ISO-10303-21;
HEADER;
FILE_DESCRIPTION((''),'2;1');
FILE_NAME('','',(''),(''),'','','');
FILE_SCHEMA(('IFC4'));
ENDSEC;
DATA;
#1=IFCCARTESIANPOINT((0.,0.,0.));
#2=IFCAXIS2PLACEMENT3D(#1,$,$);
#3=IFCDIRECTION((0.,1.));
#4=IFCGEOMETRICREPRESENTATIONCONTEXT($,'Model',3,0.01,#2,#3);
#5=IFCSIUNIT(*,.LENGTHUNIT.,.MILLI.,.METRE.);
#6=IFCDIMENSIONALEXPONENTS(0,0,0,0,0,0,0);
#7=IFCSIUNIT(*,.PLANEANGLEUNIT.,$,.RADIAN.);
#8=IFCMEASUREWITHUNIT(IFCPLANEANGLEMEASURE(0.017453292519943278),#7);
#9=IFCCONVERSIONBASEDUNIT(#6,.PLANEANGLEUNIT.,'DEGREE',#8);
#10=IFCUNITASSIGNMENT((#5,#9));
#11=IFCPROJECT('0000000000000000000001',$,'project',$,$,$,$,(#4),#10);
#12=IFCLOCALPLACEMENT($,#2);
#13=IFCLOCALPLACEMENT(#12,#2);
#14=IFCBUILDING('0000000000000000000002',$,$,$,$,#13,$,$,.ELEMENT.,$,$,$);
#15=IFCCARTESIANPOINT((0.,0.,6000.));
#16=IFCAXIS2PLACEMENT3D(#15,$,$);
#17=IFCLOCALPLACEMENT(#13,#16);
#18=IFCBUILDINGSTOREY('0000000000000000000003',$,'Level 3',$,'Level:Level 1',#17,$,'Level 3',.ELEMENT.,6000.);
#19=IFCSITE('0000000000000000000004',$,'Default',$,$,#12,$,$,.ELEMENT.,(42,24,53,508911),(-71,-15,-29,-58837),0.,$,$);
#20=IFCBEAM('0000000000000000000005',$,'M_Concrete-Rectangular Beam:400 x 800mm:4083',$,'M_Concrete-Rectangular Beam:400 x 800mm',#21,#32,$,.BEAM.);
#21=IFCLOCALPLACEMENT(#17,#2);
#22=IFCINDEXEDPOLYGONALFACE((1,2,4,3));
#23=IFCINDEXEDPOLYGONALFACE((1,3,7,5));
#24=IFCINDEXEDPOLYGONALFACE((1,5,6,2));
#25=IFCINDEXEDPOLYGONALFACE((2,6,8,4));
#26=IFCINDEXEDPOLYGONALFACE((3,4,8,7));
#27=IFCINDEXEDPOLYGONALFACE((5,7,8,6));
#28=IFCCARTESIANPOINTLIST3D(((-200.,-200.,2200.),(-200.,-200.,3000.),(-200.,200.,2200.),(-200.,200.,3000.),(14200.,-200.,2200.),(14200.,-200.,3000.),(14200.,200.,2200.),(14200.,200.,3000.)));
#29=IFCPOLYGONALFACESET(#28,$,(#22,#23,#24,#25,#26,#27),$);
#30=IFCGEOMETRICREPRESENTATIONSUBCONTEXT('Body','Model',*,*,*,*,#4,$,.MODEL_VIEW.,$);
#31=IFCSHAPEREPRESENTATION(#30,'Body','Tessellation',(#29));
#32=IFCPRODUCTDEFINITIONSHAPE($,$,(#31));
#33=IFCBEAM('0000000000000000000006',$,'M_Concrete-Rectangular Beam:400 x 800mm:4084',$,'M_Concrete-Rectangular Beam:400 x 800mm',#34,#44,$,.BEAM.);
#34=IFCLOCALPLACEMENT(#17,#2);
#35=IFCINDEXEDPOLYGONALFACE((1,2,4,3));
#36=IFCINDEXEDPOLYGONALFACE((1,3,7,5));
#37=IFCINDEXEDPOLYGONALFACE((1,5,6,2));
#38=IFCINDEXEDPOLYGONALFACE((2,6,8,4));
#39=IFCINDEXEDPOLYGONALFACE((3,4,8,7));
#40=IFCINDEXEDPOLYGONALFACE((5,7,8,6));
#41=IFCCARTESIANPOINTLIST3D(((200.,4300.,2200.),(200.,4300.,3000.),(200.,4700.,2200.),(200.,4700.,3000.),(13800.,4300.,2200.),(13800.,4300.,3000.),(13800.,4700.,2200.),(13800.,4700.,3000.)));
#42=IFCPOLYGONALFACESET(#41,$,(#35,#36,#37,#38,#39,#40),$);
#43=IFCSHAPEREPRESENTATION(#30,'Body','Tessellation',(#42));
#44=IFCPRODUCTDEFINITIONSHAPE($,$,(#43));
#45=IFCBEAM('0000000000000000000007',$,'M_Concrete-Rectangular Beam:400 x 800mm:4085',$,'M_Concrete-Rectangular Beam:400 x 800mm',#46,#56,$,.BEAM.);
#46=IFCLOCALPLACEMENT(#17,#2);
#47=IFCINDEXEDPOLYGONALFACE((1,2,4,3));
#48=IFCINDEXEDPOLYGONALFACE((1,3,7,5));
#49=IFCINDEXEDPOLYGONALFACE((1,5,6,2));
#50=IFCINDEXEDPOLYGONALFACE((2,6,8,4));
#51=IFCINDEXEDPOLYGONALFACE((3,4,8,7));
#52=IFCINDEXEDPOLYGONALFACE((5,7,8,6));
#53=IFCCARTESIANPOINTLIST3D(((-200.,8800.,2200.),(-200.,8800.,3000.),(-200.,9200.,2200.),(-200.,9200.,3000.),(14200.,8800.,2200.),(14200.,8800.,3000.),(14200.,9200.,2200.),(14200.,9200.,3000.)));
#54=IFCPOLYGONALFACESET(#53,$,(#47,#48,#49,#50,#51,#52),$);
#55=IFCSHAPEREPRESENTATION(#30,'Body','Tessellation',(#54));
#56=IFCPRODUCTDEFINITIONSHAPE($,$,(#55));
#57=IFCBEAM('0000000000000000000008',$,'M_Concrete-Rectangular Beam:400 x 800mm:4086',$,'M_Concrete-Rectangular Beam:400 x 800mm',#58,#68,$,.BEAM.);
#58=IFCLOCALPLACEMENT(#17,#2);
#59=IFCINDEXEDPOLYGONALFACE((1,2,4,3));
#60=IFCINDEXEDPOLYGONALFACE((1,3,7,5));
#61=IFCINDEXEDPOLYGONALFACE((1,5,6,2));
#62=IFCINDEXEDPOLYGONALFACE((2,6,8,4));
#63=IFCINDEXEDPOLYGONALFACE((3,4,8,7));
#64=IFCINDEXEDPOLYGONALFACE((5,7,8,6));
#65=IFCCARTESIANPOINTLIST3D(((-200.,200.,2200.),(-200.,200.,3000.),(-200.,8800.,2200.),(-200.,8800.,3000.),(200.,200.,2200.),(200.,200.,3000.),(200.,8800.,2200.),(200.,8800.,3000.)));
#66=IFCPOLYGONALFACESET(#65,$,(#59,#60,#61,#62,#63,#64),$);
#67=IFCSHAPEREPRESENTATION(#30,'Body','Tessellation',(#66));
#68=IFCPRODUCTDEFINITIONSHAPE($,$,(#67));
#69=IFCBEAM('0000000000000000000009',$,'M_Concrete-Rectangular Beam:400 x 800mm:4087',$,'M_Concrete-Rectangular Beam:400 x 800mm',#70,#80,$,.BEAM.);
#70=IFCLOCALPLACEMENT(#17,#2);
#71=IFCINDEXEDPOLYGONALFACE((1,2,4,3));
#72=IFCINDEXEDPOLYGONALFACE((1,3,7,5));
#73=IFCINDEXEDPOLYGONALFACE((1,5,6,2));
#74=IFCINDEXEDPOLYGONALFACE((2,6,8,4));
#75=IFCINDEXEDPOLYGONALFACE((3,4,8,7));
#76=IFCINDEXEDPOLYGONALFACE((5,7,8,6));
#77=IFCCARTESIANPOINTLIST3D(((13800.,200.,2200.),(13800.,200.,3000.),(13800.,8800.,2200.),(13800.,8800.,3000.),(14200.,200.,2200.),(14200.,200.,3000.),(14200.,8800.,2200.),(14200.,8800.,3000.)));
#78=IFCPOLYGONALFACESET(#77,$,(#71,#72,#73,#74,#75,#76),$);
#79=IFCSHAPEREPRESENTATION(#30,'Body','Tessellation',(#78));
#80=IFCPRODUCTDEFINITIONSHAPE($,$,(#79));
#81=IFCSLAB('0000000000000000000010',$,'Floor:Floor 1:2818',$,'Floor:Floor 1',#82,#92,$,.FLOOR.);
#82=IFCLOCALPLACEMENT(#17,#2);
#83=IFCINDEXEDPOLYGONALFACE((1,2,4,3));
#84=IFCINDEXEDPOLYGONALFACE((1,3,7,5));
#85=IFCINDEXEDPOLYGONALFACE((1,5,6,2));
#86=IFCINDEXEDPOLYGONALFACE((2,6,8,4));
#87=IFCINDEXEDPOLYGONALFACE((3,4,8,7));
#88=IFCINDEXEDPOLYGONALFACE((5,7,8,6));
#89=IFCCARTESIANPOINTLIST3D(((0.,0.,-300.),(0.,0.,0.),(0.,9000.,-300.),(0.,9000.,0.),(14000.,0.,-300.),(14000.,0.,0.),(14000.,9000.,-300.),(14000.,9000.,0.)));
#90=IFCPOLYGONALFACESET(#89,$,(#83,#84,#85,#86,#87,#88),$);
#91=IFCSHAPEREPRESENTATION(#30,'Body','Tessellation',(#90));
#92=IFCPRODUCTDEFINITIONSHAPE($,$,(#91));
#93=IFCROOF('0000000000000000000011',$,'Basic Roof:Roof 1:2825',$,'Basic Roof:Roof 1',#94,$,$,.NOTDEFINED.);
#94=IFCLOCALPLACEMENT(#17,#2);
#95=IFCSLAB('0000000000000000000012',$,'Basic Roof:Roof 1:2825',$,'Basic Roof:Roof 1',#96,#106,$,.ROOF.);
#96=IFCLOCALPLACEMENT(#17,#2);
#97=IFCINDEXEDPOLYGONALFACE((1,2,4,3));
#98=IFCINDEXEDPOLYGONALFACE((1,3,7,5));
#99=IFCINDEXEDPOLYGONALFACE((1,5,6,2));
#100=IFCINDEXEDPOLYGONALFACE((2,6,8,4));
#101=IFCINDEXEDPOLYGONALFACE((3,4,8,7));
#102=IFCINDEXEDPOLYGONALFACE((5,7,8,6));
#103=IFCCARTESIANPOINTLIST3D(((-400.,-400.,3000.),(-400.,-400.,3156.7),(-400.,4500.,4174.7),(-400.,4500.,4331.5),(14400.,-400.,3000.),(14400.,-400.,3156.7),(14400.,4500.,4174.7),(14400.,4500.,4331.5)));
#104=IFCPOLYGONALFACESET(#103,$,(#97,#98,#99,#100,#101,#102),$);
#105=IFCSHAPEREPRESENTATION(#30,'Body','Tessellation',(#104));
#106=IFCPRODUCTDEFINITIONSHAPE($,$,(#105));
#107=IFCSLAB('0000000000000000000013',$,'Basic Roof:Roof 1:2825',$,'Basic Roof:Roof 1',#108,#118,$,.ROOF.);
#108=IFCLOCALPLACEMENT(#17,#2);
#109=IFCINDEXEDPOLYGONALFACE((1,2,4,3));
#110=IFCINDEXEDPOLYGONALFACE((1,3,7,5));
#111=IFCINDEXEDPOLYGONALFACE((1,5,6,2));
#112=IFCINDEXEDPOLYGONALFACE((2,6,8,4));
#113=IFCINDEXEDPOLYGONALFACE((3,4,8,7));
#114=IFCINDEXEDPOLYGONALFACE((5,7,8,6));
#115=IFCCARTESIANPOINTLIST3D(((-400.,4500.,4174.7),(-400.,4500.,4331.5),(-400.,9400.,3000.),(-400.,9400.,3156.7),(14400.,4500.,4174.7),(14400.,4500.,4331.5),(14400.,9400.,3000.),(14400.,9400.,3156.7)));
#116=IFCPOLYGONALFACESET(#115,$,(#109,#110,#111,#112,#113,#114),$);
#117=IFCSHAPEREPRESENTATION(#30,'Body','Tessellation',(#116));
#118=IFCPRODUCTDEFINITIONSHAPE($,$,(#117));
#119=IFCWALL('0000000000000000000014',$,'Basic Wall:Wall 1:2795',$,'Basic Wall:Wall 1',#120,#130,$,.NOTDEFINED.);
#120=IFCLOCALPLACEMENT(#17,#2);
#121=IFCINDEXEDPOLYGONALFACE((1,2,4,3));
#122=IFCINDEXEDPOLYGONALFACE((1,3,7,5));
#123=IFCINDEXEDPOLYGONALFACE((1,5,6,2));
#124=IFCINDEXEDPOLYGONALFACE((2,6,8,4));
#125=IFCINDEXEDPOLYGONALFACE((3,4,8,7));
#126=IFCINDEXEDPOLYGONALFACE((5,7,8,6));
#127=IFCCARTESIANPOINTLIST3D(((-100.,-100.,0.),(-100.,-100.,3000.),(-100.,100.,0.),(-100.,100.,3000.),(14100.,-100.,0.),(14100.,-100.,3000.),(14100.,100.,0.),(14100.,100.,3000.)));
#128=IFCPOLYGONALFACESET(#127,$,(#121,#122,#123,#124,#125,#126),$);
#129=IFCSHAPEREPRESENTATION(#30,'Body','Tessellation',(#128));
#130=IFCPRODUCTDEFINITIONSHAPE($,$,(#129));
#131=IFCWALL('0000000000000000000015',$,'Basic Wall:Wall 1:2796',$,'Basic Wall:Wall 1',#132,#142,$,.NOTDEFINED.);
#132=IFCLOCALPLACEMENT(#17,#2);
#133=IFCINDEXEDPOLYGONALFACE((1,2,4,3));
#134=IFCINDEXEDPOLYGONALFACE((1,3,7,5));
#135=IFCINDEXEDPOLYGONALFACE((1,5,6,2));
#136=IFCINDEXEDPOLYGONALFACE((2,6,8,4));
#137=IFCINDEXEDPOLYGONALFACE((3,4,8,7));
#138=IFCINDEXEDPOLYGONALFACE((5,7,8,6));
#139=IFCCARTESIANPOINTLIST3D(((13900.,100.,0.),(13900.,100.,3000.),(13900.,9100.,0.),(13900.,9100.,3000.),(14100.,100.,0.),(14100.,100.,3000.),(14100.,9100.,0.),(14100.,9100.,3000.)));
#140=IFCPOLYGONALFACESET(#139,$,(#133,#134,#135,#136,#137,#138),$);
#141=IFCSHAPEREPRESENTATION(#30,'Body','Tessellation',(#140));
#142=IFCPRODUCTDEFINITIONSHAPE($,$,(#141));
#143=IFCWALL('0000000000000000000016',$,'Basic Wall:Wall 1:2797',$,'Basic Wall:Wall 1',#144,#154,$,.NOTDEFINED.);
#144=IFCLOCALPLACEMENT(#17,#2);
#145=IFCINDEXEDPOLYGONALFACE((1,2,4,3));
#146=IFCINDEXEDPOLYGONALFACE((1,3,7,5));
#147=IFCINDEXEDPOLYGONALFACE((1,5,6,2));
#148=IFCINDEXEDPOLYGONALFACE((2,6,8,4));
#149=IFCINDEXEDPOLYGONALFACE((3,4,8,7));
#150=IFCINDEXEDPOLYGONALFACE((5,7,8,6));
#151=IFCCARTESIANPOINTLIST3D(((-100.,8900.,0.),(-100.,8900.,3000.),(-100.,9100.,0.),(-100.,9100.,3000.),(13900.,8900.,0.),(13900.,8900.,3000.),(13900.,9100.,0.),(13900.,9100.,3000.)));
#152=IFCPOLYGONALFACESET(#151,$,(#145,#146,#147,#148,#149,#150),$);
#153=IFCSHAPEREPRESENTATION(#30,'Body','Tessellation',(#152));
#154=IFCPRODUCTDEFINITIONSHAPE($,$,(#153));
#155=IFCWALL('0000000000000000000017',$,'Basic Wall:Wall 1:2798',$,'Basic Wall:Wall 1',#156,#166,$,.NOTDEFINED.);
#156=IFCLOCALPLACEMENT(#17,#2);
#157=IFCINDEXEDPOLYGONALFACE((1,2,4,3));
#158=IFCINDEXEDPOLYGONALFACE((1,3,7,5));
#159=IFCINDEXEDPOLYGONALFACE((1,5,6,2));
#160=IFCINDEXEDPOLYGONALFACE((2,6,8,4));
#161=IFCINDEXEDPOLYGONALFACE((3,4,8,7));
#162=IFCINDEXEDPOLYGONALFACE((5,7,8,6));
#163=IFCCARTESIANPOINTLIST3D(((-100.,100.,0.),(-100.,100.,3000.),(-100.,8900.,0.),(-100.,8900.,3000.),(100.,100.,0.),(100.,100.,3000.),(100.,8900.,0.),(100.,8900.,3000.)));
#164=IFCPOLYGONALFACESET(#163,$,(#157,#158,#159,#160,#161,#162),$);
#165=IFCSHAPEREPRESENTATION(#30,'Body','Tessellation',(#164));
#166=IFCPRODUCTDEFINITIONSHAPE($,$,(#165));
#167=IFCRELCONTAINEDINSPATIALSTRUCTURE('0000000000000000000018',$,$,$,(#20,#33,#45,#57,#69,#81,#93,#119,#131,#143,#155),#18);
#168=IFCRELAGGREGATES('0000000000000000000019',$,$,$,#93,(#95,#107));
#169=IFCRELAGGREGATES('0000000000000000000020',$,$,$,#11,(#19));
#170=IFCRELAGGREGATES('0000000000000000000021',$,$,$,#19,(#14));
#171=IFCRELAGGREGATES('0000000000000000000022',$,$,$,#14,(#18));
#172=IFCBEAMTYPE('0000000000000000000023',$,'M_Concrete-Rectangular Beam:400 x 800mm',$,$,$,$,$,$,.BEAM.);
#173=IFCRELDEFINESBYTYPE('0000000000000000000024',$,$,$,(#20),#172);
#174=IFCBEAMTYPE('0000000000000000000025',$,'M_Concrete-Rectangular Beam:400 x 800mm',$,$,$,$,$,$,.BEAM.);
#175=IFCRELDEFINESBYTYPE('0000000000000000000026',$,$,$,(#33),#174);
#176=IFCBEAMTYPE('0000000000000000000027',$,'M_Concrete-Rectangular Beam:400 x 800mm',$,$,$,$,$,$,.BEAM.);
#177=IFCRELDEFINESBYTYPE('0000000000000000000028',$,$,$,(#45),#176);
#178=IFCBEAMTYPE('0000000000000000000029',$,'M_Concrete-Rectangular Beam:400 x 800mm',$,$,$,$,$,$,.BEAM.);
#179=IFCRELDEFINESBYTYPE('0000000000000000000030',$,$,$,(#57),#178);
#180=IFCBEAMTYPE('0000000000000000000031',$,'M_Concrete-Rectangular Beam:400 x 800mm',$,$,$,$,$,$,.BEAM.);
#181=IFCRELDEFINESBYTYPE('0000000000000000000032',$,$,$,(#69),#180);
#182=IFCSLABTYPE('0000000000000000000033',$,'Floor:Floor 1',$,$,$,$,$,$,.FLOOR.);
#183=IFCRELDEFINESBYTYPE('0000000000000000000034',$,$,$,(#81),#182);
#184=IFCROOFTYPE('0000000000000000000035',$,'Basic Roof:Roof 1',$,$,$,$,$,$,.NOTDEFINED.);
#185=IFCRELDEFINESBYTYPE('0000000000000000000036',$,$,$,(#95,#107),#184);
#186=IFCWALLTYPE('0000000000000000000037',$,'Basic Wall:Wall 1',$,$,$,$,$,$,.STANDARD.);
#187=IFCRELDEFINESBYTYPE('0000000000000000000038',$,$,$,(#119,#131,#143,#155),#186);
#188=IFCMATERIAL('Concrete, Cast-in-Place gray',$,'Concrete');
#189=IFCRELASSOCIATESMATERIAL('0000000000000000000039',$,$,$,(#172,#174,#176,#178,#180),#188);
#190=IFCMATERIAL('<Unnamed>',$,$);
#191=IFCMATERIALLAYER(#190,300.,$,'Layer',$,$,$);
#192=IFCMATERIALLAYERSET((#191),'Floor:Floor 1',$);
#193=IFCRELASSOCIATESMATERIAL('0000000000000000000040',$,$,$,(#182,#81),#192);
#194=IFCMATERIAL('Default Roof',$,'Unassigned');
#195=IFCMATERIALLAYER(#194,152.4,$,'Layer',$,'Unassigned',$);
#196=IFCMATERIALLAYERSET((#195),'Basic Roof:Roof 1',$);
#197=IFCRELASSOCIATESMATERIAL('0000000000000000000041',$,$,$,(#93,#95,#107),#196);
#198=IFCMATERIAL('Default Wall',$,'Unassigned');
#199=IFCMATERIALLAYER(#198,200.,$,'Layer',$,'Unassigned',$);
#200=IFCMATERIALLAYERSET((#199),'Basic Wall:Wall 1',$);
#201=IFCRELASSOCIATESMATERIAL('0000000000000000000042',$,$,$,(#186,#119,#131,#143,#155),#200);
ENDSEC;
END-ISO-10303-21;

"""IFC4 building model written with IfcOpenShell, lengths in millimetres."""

from ifc_helpers import new_model, entity, si_unit, converted_unit, direction, frame, frame_2d, origin, origin_2d_with_axis, place, context, subcontext, project, spatial, rectangle, extrude, source, transform, mapped, material, layer, layer_set, layer_usage, material_profile, profile_set, type_object, type_shapes, element, aggregate, save


model = new_model("IFC4")

# Units and contexts
model_context = context("Model", 3, precision=0.01, world=origin(), true_north=direction((0.0, 1.0)))
body_context = subcontext(model_context, "Body", "Model", "MODEL_VIEW")
ifc_project = project(units=[si_unit("LENGTHUNIT", "METRE", prefix="MILLI"), converted_unit("PLANEANGLEUNIT", "DEGREE", entity("IfcPlaneAngleMeasure", 0.017453292519943278), si_unit("PLANEANGLEUNIT", "RADIAN"), dimensions=[0, 0, 0, 0, 0, 0, 0])], contexts=[model_context])

# Site, building, storey
site_placement = place(None, origin())
site = spatial("IfcSite", under=ifc_project, at=site_placement, Name="Default", CompositionType="ELEMENT", RefLatitude=(42, 24, 53, 508911), RefLongitude=(-71, -15, -29, -58837), RefElevation=0.0)
building_placement = place(site_placement, origin())
building = spatial("IfcBuilding", under=site, at=building_placement, CompositionType="ELEMENT")
storey_placement = place(building_placement, frame((0.0, 0.0, 6000.0)))
storey = spatial("IfcBuildingStorey", under=building, at=storey_placement, Name="Level 3", ObjectType="Level:Level 1", LongName="Level 3", CompositionType="ELEMENT", Elevation=6000.0)

# Beams
ifc_material_1 = material(Name="Concrete, Cast-in-Place gray", Category="Concrete")
ifc_material_profile = material_profile(ifc_material_1, rectangle(XDim=800.0, YDim=400.0, at=origin_2d_with_axis()), Name="400 x 800mm")
ifc_profile_set = profile_set([ifc_material_profile], Name="400 x 800mm")
beam_type_1 = type_object("IfcBeamType", Name="M_Concrete-Rectangular Beam:400 x 800mm", PredefinedType="BEAM", material=ifc_profile_set)
shared_shape_1 = source(origin(), body_context, "Body", "SweptSolid", [
    extrude(rectangle(XDim=800.0, YDim=400.0, at=origin_2d_with_axis()), frame((-200.0, 0.0, 8600.0), z_axis=(1.0, 0.0, 0.0), x_axis=(0.0, 0.0, -1.0)), (0.0, 0.0, 1.0), 14400.0),
])
type_shapes(beam_type_1, [shared_shape_1])
beam_1_placement = place(storey_placement, frame((0.0, 0.0, -6000.0)))
element("IfcBeam", 1, at=beam_1_placement, inside=storey, type_object=beam_type_1, Name="M_Concrete-Rectangular Beam:400 x 800mm:4083", ObjectType="M_Concrete-Rectangular Beam:400 x 800mm", PredefinedType="BEAM", context=body_context, shape_type="MappedRepresentation", body=[
    mapped(shared_shape_1, transform((0.0, 0.0, 0.0), scale=1.0)),
])
beam_type_2 = type_object("IfcBeamType", Name="M_Concrete-Rectangular Beam:400 x 800mm", PredefinedType="BEAM", material=ifc_profile_set)
shared_shape_2 = source(origin(), body_context, "Body", "SweptSolid", [
    extrude(rectangle(XDim=800.0, YDim=400.0, at=origin_2d_with_axis()), frame((200.0, 4500.0, 8600.0), z_axis=(1.0, 0.0, 0.0), x_axis=(0.0, 0.0, -1.0)), (0.0, 0.0, 1.0), 13600.0),
])
type_shapes(beam_type_2, [shared_shape_2])
beam_2_placement = place(storey_placement, frame((0.0, 0.0, -6000.0)))
element("IfcBeam", 2, at=beam_2_placement, inside=storey, type_object=beam_type_2, Name="M_Concrete-Rectangular Beam:400 x 800mm:4084", ObjectType="M_Concrete-Rectangular Beam:400 x 800mm", PredefinedType="BEAM", context=body_context, shape_type="MappedRepresentation", body=[
    mapped(shared_shape_2, transform((0.0, 0.0, 0.0), scale=1.0)),
])
beam_type_3 = type_object("IfcBeamType", Name="M_Concrete-Rectangular Beam:400 x 800mm", PredefinedType="BEAM", material=ifc_profile_set)
shared_shape_3 = source(origin(), body_context, "Body", "SweptSolid", [
    extrude(rectangle(XDim=800.0, YDim=400.0, at=frame_2d((0.0, 0.0), x_axis=(1.0, 0.0))), frame((-200.0, 9000.0, 8600.0), z_axis=(1.0, 0.0, 0.0), x_axis=(0.0, 0.0, -1.0)), (0.0, 0.0, 1.0), 14400.0),
])
type_shapes(beam_type_3, [shared_shape_3])
beam_3_placement = place(storey_placement, frame((0.0, 0.0, -6000.0)))
element("IfcBeam", 3, at=beam_3_placement, inside=storey, type_object=beam_type_3, Name="M_Concrete-Rectangular Beam:400 x 800mm:4085", ObjectType="M_Concrete-Rectangular Beam:400 x 800mm", PredefinedType="BEAM", context=body_context, shape_type="MappedRepresentation", body=[
    mapped(shared_shape_3, transform((0.0, 0.0, 0.0), scale=1.0)),
])
beam_type_4 = type_object("IfcBeamType", Name="M_Concrete-Rectangular Beam:400 x 800mm", PredefinedType="BEAM", material=ifc_profile_set)
shared_shape_4 = source(origin(), body_context, "Body", "SweptSolid", [
    extrude(rectangle(XDim=800.0, YDim=400.0, at=frame_2d((0.0, 0.0), x_axis=(0.0, 1.0))), frame((0.0, 200.0, 8600.0), z_axis=(0.0, 1.0, 0.0), x_axis=(-1.0, 0.0, 0.0)), (0.0, 0.0, 1.0), 8600.0),
])
type_shapes(beam_type_4, [shared_shape_4])
beam_4_placement = place(storey_placement, frame((0.0, 0.0, -6000.0)))
element("IfcBeam", 4, at=beam_4_placement, inside=storey, type_object=beam_type_4, Name="M_Concrete-Rectangular Beam:400 x 800mm:4086", ObjectType="M_Concrete-Rectangular Beam:400 x 800mm", PredefinedType="BEAM", context=body_context, shape_type="MappedRepresentation", body=[
    mapped(shared_shape_4, transform((0.0, 0.0, 0.0), scale=1.0)),
])
beam_type_5 = type_object("IfcBeamType", Name="M_Concrete-Rectangular Beam:400 x 800mm", PredefinedType="BEAM", material=ifc_profile_set)
shared_shape_5 = source(origin(), body_context, "Body", "SweptSolid", [
    extrude(rectangle(XDim=800.0, YDim=400.0, at=frame_2d((0.0, 0.0), x_axis=(0.0, 1.0))), frame((14000.0, 200.0, 8600.0), z_axis=(0.0, 1.0, 0.0), x_axis=(-1.0, 0.0, 0.0)), (0.0, 0.0, 1.0), 8600.0),
])
type_shapes(beam_type_5, [shared_shape_5])
beam_5_placement = place(storey_placement, frame((0.0, 0.0, -6000.0)))
element("IfcBeam", 5, at=beam_5_placement, inside=storey, type_object=beam_type_5, Name="M_Concrete-Rectangular Beam:400 x 800mm:4087", ObjectType="M_Concrete-Rectangular Beam:400 x 800mm", PredefinedType="BEAM", context=body_context, shape_type="MappedRepresentation", body=[
    mapped(shared_shape_5, transform((0.0, 0.0, 0.0), scale=1.0)),
])

# Slab
ifc_material_2 = material(Name="<Unnamed>")
ifc_layer_1 = layer(ifc_material_2, 300.0, Name="Layer")
ifc_layer_set_1 = layer_set([ifc_layer_1], Name="Floor:Floor 1")
ifc_layer_usage_1 = layer_usage(ifc_layer_set_1, "AXIS3", "POSITIVE", 0.0)
slab_type = type_object("IfcSlabType", Name="Floor:Floor 1", PredefinedType="FLOOR", material=ifc_layer_set_1)
slab_1_placement = place(storey_placement, origin())
element("IfcSlab", 6, at=slab_1_placement, inside=storey, type_object=slab_type, material=ifc_layer_usage_1, Name="Floor:Floor 1:2818", ObjectType="Floor:Floor 1", PredefinedType="FLOOR", context=body_context, shape_type="SweptSolid", body=[
    extrude(rectangle(XDim=9000.0, YDim=14000.0, at=origin_2d_with_axis()), frame((7000.0, 4500.0, 0.0), z_axis=(0.0, 0.0, -1.0), x_axis=(0.0, 1.0, 0.0)), (0.0, 0.0, 1.0), 300.0),
])

# Roof, slabs
ifc_material_3 = material(Name="Default Roof", Category="Unassigned")
ifc_layer_2 = layer(ifc_material_3, 152.4, Name="Layer", Category="Unassigned")
ifc_layer_set_2 = layer_set([ifc_layer_2], Name="Basic Roof:Roof 1")
roof_placement = place(storey_placement, frame((-400.0, -400.0, 3000.0)))
roof = element("IfcRoof", 7, at=roof_placement, inside=storey, material=ifc_layer_set_2, Name="Basic Roof:Roof 1:2825", ObjectType="Basic Roof:Roof 1", PredefinedType="NOTDEFINED")
roof_type = type_object("IfcRoofType", Name="Basic Roof:Roof 1", PredefinedType="NOTDEFINED")
slab_2_placement = place(roof_placement, origin())
slab_2 = element("IfcSlab", 8, at=slab_2_placement, type_object=roof_type, material=ifc_layer_set_2, Name="Basic Roof:Roof 1:2825", ObjectType="Basic Roof:Roof 1", PredefinedType="ROOF", context=body_context, shape_type="SweptSolid", body=[
    extrude(rectangle(XDim=14800.0, YDim=5038.9, at=frame_2d((0.0, 0.0), x_axis=(-1.0, 0.0))), frame((7400.0, 2450.0, 587.4), z_axis=(0.0, -0.233137, 0.972444), x_axis=(1.0, 0.0, 0.0)), (0.0, 0.233137, 0.972444), 156.7),
])
slab_3_placement = place(roof_placement, origin())
slab_3 = element("IfcSlab", 9, at=slab_3_placement, type_object=roof_type, material=ifc_layer_set_2, Name="Basic Roof:Roof 1:2825", ObjectType="Basic Roof:Roof 1", PredefinedType="ROOF", context=body_context, shape_type="SweptSolid", body=[
    extrude(rectangle(XDim=5038.9, YDim=14800.0, at=frame_2d((0.0, 0.0), x_axis=(0.0, -1.0))), frame((7400.0, 7350.0, 587.4), z_axis=(0.0, 0.233137, 0.972444), x_axis=(1.0, 0.0, 0.0)), (0.0, -0.233137, 0.972444), 156.7),
])
aggregate(roof, [slab_2, slab_3])

# Walls
ifc_material_4 = material(Name="Default Wall", Category="Unassigned")
ifc_layer_3 = layer(ifc_material_4, 200.0, Name="Layer", Category="Unassigned")
ifc_layer_set_3 = layer_set([ifc_layer_3], Name="Basic Wall:Wall 1")
ifc_layer_usage_2 = layer_usage(ifc_layer_set_3, "AXIS2", "NEGATIVE", 100.0)
wall_type = type_object("IfcWallType", Name="Basic Wall:Wall 1", PredefinedType="STANDARD", material=ifc_layer_set_3)
wall_1_placement = place(storey_placement, frame((-100.0, 0.0, 0.0)))
element("IfcWall", 10, at=wall_1_placement, inside=storey, type_object=wall_type, material=ifc_layer_usage_2, Name="Basic Wall:Wall 1:2795", ObjectType="Basic Wall:Wall 1", PredefinedType="NOTDEFINED", context=body_context, shape_type="SweptSolid", body=[
    extrude(rectangle(XDim=14200.0, YDim=200.0, at=frame_2d((7100.0, 0.0), x_axis=(-1.0, 0.0))), origin(), (0.0, 0.0, 1.0), 3000.0),
])
ifc_layer_usage_3 = layer_usage(ifc_layer_set_3, "AXIS2", "NEGATIVE", 100.0)
wall_2_placement = place(storey_placement, frame((14000.0, 100.0, 0.0), z_axis=(0.0, 0.0, 1.0), x_axis=(0.0, 1.0, 0.0)))
element("IfcWall", 11, at=wall_2_placement, inside=storey, type_object=wall_type, material=ifc_layer_usage_3, Name="Basic Wall:Wall 1:2796", ObjectType="Basic Wall:Wall 1", PredefinedType="NOTDEFINED", context=body_context, shape_type="SweptSolid", body=[
    extrude(rectangle(XDim=9000.0, YDim=200.0, at=frame_2d((4500.0, 0.0), x_axis=(-1.0, 0.0))), origin(), (0.0, 0.0, 1.0), 3000.0),
])
ifc_layer_usage_4 = layer_usage(ifc_layer_set_3, "AXIS2", "NEGATIVE", 100.0)
wall_3_placement = place(storey_placement, frame((13900.0, 9000.0, 0.0), z_axis=(0.0, 0.0, 1.0), x_axis=(-1.0, 0.0, 0.0)))
element("IfcWall", 12, at=wall_3_placement, inside=storey, type_object=wall_type, material=ifc_layer_usage_4, Name="Basic Wall:Wall 1:2797", ObjectType="Basic Wall:Wall 1", PredefinedType="NOTDEFINED", context=body_context, shape_type="SweptSolid", body=[
    extrude(rectangle(XDim=14000.0, YDim=200.0, at=frame_2d((7000.0, 0.0), x_axis=(-1.0, 0.0))), origin(), (0.0, 0.0, 1.0), 3000.0),
])
ifc_layer_usage_5 = layer_usage(ifc_layer_set_3, "AXIS2", "NEGATIVE", 100.0)
wall_4_placement = place(storey_placement, frame((0.0, 8900.0, 0.0), z_axis=(0.0, 0.0, 1.0), x_axis=(0.0, -1.0, 0.0)))
element("IfcWall", 13, at=wall_4_placement, inside=storey, type_object=wall_type, material=ifc_layer_usage_5, Name="Basic Wall:Wall 1:2798", ObjectType="Basic Wall:Wall 1", PredefinedType="NOTDEFINED", context=body_context, shape_type="SweptSolid", body=[
    extrude(rectangle(XDim=8800.0, YDim=200.0, at=frame_2d((4400.0, 0.0), x_axis=(-1.0, 0.0))), origin(), (0.0, 0.0, 1.0), 3000.0),
])

save(model, "model.ifc")
